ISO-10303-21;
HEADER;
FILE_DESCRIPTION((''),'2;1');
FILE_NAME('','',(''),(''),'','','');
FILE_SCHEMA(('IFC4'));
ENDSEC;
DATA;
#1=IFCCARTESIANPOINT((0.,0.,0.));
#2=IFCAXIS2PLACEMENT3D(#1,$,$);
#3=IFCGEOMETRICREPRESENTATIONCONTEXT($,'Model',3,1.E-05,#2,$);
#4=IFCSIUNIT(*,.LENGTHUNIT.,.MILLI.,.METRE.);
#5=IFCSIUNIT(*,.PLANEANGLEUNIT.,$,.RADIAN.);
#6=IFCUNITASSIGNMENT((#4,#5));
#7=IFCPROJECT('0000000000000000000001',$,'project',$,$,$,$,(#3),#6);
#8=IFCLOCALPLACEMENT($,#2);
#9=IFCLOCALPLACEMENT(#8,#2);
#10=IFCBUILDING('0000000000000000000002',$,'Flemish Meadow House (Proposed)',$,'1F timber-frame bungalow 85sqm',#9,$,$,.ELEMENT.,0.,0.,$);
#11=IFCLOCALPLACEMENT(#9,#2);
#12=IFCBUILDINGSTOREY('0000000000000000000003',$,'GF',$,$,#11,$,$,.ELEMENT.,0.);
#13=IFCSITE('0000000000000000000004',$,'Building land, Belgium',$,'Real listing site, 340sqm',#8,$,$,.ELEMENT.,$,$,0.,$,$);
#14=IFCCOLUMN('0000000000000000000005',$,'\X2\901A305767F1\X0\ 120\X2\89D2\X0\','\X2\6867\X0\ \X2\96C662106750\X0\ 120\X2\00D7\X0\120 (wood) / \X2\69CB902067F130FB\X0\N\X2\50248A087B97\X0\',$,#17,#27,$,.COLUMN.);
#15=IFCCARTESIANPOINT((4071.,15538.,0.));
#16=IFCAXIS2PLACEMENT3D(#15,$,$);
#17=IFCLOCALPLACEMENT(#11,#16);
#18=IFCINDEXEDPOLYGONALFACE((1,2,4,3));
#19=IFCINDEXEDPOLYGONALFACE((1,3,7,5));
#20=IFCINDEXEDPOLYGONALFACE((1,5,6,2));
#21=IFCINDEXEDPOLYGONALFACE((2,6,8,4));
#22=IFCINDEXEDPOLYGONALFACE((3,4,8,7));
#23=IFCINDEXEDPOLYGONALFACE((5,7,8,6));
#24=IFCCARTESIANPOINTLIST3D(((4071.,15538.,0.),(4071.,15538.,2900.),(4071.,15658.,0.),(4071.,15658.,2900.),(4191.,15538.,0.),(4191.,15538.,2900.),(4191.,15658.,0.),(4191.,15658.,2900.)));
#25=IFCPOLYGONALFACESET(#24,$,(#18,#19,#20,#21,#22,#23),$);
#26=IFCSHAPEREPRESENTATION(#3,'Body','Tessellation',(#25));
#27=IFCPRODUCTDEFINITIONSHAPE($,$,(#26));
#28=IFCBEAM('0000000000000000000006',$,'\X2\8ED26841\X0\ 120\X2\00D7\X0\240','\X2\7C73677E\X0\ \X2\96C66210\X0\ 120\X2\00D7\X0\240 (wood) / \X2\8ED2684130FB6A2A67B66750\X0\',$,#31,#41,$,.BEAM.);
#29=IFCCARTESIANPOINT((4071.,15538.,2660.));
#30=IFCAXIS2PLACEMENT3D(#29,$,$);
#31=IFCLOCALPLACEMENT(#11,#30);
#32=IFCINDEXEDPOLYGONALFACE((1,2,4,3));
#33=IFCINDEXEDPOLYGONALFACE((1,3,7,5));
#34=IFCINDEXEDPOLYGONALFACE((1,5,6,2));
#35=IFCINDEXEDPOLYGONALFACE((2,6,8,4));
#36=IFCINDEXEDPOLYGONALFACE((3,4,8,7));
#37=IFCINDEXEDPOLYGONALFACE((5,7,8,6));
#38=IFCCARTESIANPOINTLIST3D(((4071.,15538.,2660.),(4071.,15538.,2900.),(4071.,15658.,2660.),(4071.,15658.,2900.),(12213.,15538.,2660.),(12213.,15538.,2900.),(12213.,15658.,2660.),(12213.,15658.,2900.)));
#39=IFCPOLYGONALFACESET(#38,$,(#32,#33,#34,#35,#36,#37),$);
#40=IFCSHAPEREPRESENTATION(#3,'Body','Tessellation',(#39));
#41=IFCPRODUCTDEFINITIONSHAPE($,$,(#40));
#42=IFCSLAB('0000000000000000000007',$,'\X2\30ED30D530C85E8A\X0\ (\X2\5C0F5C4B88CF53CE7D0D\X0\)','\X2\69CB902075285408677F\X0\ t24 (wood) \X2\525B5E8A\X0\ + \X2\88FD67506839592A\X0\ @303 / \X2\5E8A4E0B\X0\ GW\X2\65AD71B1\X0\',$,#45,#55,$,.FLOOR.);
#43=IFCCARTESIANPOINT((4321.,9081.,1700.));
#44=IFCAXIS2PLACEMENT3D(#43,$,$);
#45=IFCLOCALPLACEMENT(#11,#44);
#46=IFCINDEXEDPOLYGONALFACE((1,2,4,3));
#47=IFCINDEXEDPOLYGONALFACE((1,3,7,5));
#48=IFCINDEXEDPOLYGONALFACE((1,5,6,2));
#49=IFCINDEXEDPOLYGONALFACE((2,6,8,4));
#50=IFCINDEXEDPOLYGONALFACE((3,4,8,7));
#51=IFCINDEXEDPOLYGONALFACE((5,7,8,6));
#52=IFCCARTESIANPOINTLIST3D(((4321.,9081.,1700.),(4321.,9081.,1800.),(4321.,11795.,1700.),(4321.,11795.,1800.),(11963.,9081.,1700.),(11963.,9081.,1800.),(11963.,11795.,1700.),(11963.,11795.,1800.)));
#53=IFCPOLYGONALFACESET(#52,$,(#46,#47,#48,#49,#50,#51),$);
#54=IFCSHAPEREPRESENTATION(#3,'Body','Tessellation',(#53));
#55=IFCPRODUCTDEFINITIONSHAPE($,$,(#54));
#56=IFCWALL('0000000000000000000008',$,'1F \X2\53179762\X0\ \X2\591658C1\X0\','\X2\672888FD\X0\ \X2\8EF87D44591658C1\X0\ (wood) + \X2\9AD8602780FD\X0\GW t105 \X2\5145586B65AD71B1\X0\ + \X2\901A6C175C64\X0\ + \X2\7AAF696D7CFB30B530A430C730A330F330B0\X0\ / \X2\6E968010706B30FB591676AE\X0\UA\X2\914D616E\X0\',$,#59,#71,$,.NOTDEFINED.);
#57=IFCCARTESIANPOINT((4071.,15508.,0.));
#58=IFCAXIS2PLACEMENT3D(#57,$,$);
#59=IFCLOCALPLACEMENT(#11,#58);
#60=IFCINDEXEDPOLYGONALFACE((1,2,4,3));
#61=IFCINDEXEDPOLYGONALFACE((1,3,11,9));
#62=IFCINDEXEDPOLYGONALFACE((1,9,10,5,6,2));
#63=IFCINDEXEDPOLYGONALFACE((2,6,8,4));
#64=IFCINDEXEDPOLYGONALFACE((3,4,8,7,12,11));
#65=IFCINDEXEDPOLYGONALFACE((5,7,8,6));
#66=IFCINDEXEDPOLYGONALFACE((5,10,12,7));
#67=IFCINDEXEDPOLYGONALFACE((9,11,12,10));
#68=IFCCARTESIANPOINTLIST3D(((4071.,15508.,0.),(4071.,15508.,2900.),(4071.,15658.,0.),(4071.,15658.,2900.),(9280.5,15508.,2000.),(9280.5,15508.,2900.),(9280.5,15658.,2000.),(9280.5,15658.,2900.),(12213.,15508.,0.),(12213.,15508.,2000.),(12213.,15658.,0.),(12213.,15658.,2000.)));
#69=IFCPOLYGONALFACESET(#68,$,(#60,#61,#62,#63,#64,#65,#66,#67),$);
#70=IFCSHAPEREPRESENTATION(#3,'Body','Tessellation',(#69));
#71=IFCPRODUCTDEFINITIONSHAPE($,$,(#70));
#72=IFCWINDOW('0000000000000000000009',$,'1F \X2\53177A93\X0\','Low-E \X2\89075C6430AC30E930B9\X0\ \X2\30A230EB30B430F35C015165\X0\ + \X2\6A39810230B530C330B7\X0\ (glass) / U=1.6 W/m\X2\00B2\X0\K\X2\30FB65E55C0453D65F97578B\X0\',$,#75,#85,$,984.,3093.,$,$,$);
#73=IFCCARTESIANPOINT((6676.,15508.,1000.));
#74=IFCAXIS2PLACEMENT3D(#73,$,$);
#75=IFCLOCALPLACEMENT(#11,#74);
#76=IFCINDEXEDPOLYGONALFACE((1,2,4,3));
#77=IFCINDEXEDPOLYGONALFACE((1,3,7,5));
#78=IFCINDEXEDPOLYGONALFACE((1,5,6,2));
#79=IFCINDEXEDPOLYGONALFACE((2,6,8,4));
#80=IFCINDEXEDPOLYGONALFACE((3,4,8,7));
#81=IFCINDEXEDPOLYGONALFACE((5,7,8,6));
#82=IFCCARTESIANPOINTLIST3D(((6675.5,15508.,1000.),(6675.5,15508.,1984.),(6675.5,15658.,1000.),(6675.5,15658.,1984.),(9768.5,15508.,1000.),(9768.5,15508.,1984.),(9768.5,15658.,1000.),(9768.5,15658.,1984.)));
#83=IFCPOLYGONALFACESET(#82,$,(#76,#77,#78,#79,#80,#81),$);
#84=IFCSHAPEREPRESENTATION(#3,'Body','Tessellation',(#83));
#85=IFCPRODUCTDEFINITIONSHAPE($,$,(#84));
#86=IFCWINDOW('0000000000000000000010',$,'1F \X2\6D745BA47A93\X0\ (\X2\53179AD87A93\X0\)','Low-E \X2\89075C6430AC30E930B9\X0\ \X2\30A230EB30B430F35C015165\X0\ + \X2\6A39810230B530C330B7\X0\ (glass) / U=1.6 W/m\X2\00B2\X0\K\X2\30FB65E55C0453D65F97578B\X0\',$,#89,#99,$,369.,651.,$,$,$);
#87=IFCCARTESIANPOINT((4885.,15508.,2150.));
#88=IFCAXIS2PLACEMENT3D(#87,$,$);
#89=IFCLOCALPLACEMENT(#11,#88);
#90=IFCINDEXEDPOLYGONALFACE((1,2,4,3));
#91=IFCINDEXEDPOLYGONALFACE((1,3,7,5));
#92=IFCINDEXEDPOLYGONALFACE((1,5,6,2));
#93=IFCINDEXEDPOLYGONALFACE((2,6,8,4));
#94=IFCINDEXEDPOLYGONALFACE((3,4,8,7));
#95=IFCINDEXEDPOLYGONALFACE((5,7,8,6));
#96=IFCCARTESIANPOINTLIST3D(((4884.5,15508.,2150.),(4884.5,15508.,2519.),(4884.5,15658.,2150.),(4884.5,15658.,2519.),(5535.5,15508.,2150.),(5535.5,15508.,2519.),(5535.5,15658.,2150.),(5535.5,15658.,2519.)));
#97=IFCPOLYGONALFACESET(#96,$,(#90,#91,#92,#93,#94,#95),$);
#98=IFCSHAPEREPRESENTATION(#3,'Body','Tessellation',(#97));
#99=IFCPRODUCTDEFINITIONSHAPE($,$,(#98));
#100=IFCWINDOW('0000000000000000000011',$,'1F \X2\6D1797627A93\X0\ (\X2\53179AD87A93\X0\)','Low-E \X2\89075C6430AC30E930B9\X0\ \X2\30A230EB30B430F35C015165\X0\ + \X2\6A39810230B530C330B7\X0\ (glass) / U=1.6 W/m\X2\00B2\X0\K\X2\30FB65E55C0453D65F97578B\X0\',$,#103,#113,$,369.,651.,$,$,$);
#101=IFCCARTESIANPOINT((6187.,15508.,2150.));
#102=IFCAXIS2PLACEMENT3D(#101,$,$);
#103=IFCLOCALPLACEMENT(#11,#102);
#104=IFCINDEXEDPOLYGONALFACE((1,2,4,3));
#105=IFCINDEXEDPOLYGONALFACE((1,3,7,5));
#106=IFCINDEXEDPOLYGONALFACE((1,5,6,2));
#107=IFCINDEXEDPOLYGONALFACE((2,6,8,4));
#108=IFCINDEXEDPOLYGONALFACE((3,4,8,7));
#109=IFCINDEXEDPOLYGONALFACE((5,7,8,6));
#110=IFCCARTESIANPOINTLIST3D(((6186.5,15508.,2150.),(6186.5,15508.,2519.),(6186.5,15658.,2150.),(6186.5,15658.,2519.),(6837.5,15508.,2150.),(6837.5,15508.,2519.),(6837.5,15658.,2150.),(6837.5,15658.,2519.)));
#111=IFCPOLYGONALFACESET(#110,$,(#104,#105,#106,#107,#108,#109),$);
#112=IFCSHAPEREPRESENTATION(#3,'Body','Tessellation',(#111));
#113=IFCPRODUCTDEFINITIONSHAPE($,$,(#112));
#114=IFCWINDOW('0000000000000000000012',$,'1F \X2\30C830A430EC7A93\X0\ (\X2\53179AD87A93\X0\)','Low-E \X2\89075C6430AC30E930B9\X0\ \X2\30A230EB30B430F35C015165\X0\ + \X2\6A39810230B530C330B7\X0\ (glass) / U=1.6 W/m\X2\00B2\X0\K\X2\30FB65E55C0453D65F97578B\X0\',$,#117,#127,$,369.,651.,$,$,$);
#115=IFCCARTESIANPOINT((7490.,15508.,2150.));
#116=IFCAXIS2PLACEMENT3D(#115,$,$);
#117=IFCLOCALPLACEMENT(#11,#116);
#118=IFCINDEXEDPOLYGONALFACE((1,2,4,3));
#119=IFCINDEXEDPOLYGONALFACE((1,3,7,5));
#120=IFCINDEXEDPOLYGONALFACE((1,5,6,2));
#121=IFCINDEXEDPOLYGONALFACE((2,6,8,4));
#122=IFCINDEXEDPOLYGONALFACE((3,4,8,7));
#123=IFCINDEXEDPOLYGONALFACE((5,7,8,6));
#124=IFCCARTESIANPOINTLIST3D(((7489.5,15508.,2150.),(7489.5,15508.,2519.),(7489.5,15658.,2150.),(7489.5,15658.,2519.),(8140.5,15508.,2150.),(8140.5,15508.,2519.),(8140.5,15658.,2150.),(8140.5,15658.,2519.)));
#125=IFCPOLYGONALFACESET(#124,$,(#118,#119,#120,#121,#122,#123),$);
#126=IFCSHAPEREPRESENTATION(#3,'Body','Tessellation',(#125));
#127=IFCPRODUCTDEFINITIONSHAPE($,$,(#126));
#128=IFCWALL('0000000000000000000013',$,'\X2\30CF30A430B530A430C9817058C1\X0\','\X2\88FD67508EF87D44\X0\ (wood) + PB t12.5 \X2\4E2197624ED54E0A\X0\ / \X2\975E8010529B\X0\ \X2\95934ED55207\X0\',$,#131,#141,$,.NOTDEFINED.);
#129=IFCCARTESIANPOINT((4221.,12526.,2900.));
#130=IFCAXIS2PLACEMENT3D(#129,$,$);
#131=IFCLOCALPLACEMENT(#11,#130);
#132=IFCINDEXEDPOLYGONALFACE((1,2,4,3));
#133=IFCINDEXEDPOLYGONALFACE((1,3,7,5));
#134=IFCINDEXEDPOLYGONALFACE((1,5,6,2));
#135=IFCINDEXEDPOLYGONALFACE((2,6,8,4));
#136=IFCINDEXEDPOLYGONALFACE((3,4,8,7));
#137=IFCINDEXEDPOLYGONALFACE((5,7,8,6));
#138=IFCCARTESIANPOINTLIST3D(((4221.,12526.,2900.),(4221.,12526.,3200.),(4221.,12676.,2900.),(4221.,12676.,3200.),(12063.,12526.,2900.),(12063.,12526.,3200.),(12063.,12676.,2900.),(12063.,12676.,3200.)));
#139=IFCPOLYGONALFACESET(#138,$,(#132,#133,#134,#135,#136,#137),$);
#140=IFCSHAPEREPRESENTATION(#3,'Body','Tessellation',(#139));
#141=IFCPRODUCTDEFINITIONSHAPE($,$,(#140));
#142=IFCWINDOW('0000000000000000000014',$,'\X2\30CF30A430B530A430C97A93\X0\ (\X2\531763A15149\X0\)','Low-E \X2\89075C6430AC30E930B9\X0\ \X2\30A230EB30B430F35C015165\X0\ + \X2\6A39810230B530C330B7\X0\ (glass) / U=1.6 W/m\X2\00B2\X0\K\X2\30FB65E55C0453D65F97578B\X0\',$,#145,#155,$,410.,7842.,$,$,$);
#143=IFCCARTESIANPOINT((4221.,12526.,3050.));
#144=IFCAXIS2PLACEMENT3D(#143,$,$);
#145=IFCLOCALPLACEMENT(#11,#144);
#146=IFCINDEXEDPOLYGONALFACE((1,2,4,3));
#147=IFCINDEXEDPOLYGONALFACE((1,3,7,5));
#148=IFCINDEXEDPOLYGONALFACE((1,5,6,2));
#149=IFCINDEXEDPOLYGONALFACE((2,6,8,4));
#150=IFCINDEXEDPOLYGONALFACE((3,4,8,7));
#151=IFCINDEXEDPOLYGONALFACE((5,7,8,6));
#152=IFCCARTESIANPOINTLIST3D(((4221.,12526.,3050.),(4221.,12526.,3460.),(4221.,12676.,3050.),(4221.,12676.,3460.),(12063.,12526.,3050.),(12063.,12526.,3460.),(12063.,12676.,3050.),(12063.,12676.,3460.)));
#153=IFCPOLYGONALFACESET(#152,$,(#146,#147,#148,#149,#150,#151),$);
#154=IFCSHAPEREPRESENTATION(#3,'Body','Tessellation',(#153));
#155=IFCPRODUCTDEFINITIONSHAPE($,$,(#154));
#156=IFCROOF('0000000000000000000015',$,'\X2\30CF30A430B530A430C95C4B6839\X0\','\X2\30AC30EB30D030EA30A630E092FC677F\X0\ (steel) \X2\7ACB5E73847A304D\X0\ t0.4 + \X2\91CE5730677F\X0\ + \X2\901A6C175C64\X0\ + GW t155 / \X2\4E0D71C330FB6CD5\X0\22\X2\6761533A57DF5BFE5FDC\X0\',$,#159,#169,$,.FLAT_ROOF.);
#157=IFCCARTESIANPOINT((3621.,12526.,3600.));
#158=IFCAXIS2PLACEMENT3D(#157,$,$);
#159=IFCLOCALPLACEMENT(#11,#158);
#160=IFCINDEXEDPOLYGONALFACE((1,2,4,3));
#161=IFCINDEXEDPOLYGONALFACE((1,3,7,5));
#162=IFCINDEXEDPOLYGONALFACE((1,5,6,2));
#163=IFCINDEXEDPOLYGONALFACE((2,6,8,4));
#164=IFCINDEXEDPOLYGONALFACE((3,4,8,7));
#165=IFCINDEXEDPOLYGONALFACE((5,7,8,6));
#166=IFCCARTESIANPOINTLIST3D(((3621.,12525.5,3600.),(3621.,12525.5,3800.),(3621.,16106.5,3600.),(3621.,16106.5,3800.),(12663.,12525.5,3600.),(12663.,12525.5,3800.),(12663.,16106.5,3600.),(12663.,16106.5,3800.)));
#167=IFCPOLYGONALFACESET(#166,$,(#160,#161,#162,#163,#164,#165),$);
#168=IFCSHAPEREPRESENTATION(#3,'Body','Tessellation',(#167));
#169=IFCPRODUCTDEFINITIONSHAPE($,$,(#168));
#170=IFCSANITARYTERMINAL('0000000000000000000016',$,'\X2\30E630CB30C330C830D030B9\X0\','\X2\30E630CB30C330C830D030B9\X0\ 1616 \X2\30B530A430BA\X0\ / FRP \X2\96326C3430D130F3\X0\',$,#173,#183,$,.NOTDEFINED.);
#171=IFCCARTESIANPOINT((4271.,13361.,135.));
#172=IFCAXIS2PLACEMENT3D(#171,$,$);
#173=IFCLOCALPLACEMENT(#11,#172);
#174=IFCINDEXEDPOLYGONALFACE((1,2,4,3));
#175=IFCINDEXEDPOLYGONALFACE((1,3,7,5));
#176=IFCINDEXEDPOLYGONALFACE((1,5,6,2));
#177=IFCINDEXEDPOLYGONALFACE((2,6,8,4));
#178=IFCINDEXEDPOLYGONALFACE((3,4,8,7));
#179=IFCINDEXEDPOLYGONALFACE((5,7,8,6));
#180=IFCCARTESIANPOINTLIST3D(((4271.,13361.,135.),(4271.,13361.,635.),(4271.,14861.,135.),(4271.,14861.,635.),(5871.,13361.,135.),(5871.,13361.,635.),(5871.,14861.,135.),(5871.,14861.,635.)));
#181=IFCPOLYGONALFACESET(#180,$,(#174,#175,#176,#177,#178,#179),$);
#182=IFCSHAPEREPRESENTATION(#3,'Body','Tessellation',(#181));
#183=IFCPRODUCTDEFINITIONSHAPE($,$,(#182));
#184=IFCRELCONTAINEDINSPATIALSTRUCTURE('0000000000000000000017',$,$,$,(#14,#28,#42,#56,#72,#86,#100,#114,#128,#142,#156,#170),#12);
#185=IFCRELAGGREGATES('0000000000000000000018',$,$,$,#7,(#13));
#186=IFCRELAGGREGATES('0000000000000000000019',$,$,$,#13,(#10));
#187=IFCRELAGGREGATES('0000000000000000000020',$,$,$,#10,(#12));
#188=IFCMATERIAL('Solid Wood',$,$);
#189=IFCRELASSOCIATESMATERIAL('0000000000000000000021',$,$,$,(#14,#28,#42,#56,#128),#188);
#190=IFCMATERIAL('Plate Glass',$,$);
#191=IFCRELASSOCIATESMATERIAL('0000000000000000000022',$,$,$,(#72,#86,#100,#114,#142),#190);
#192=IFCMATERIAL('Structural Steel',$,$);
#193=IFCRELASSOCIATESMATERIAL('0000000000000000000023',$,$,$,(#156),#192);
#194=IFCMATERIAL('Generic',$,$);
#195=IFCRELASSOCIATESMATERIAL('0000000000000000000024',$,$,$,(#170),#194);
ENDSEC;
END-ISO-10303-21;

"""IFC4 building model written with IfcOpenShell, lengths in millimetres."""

from ifc_helpers import new_model, si_unit, frame, frame_2d, origin, place, context, project, spatial, rectangle, extrude, material, element, fill, save


model = new_model("IFC4")

# Units and contexts
model_context = context("Model", 3, precision=1e-05, world=origin())
ifc_project = project(units=[si_unit("LENGTHUNIT", "METRE", prefix="MILLI"), si_unit("PLANEANGLEUNIT", "RADIAN")], contexts=[model_context])

# Site, building, storey
site_placement = place(None, origin())
site = spatial("IfcSite", under=ifc_project, at=site_placement, Name="Building land, Belgium", ObjectType="Real listing site, 340sqm", CompositionType="ELEMENT", RefElevation=0.0)
building_placement = place(site_placement, origin())
building = spatial("IfcBuilding", under=site, at=building_placement, Name="Flemish Meadow House (Proposed)", ObjectType="1F timber-frame bungalow 85sqm", CompositionType="ELEMENT", ElevationOfRefHeight=0.0, ElevationOfTerrain=0.0)
storey_placement = place(building_placement, origin())
storey = spatial("IfcBuildingStorey", under=building, at=storey_placement, Name="GF", CompositionType="ELEMENT", Elevation=0.0)

# Column
ifc_material_1 = material(Name="Solid Wood")
column_1_placement = place(storey_placement, frame((4071.0, 15538.0, 0.0)))
element("IfcColumn", 1, at=column_1_placement, inside=storey, material=ifc_material_1, Name="通し柱 120角", Description="桧 集成材 120×120 (wood) / 構造柱・N値計算", PredefinedType="COLUMN", context=model_context, shape_type="SweptSolid", body=[
    extrude(rectangle(XDim=120.0, YDim=120.0, at=frame_2d((60.0, 60.0))), frame((4071.0, 15538.0, 0.0)), (0.0, 0.0, 1.0), 2900.0),
])

# Beam
beam_1_placement = place(storey_placement, frame((4071.0, 15538.0, 2660.0)))
element("IfcBeam", 2, at=beam_1_placement, inside=storey, material=ifc_material_1, Name="軒桁 120×240", Description="米松 集成 120×240 (wood) / 軒桁・横架材", PredefinedType="BEAM", context=model_context, shape_type="SweptSolid", body=[
    extrude(rectangle(XDim=8142.0, YDim=120.0, at=frame_2d((4071.0, 60.0))), frame((4071.0, 15538.0, 2660.0)), (0.0, 0.0, 1.0), 240.0),
])

# Slab
slab_placement = place(storey_placement, frame((4321.0, 9081.0, 1700.0)))
element("IfcSlab", 3, at=slab_placement, inside=storey, material=ifc_material_1, Name="ロフト床 (小屋裏収納)", Description="構造用合板 t24 (wood) 剛床 + 製材根太 @303 / 床下 GW断熱", PredefinedType="FLOOR", context=model_context, shape_type="SweptSolid", body=[
    extrude(rectangle(XDim=7642.0, YDim=2714.0, at=frame_2d((3821.0, 1357.0))), frame((4321.0, 9081.0, 1700.0)), (0.0, 0.0, 1.0), 100.0),
])

# Wall, openings, windows
wall_1_placement = place(storey_placement, frame((4071.0, 15508.0, 0.0)))
wall_1 = element("IfcWall", 4, at=wall_1_placement, inside=storey, material=ifc_material_1, Name="1F 北面 外壁", Description="木製 軸組外壁 (wood) + 高性能GW t105 充填断熱 + 通気層 + 窯業系サイディング / 準耐火・外皮UA配慮", PredefinedType="NOTDEFINED", context=model_context, shape_type="SweptSolid", body=[
    extrude(rectangle(XDim=8142.0, YDim=150.0, at=frame_2d((4071.0, 75.0))), frame((4071.0, 15508.0, 0.0)), (0.0, 0.0, 1.0), 2900.0),
])
opening_1_placement = place(storey_placement, frame((6676.0, 15508.0, 1000.0)))
opening_1 = element("IfcOpeningElement", 5, at=opening_1_placement, cuts=wall_1, PredefinedType="NOTDEFINED", context=model_context, shape_type="SweptSolid", body=[
    extrude(rectangle(XDim=3093.0, YDim=150.0, at=frame_2d((1546.0, 75.0))), frame((6676.0, 15508.0, 1000.0)), (0.0, 0.0, 1.0), 984.0),
])
opening_2_placement = place(storey_placement, frame((4885.0, 15508.0, 2150.0)))
opening_2 = element("IfcOpeningElement", 6, at=opening_2_placement, cuts=wall_1, PredefinedType="NOTDEFINED", context=model_context, shape_type="SweptSolid", body=[
    extrude(rectangle(XDim=651.0, YDim=150.0, at=frame_2d((325.0, 75.0))), frame((4885.0, 15508.0, 2150.0)), (0.0, 0.0, 1.0), 369.0),
])
opening_3_placement = place(storey_placement, frame((6187.0, 15508.0, 2150.0)))
opening_3 = element("IfcOpeningElement", 7, at=opening_3_placement, cuts=wall_1, PredefinedType="NOTDEFINED", context=model_context, shape_type="SweptSolid", body=[
    extrude(rectangle(XDim=651.0, YDim=150.0, at=frame_2d((325.0, 75.0))), frame((6187.0, 15508.0, 2150.0)), (0.0, 0.0, 1.0), 369.0),
])
opening_4_placement = place(storey_placement, frame((7490.0, 15508.0, 2150.0)))
opening_4 = element("IfcOpeningElement", 8, at=opening_4_placement, cuts=wall_1, PredefinedType="NOTDEFINED", context=model_context, shape_type="SweptSolid", body=[
    extrude(rectangle(XDim=651.0, YDim=150.0, at=frame_2d((325.0, 75.0))), frame((7490.0, 15508.0, 2150.0)), (0.0, 0.0, 1.0), 369.0),
])
ifc_material_2 = material(Name="Plate Glass")
window_1_placement = place(storey_placement, frame((6676.0, 15508.0, 1000.0)))
window_1 = element("IfcWindow", 9, at=window_1_placement, inside=storey, material=ifc_material_2, Name="1F 北窓", Description="Low-E 複層ガラス アルゴン封入 + 樹脂サッシ (glass) / U=1.6 W/m²K・日射取得型", OverallHeight=984.0, OverallWidth=3093.0, context=model_context, shape_type="SweptSolid", body=[
    extrude(rectangle(XDim=3093.0, YDim=150.0, at=frame_2d((1546.0, 75.0))), frame((6676.0, 15508.0, 1000.0)), (0.0, 0.0, 1.0), 984.0),
])
fill(opening_1, window_1)
window_2_placement = place(storey_placement, frame((4885.0, 15508.0, 2150.0)))
window_2 = element("IfcWindow", 10, at=window_2_placement, inside=storey, material=ifc_material_2, Name="1F 浴室窓 (北高窓)", Description="Low-E 複層ガラス アルゴン封入 + 樹脂サッシ (glass) / U=1.6 W/m²K・日射取得型", OverallHeight=369.0, OverallWidth=651.0, context=model_context, shape_type="SweptSolid", body=[
    extrude(rectangle(XDim=651.0, YDim=150.0, at=frame_2d((325.0, 75.0))), frame((4885.0, 15508.0, 2150.0)), (0.0, 0.0, 1.0), 369.0),
])
fill(opening_2, window_2)
window_3_placement = place(storey_placement, frame((6187.0, 15508.0, 2150.0)))
window_3 = element("IfcWindow", 11, at=window_3_placement, inside=storey, material=ifc_material_2, Name="1F 洗面窓 (北高窓)", Description="Low-E 複層ガラス アルゴン封入 + 樹脂サッシ (glass) / U=1.6 W/m²K・日射取得型", OverallHeight=369.0, OverallWidth=651.0, context=model_context, shape_type="SweptSolid", body=[
    extrude(rectangle(XDim=651.0, YDim=150.0, at=frame_2d((325.0, 75.0))), frame((6187.0, 15508.0, 2150.0)), (0.0, 0.0, 1.0), 369.0),
])
fill(opening_3, window_3)
window_4_placement = place(storey_placement, frame((7490.0, 15508.0, 2150.0)))
window_4 = element("IfcWindow", 12, at=window_4_placement, inside=storey, material=ifc_material_2, Name="1F トイレ窓 (北高窓)", Description="Low-E 複層ガラス アルゴン封入 + 樹脂サッシ (glass) / U=1.6 W/m²K・日射取得型", OverallHeight=369.0, OverallWidth=651.0, context=model_context, shape_type="SweptSolid", body=[
    extrude(rectangle(XDim=651.0, YDim=150.0, at=frame_2d((325.0, 75.0))), frame((7490.0, 15508.0, 2150.0)), (0.0, 0.0, 1.0), 369.0),
])
fill(opening_4, window_4)

# Wall, opening, window
wall_2_placement = place(storey_placement, frame((4221.0, 12526.0, 2900.0)))
wall_2 = element("IfcWall", 13, at=wall_2_placement, inside=storey, material=ifc_material_1, Name="ハイサイド腰壁", Description="製材軸組 (wood) + PB t12.5 両面仕上 / 非耐力 間仕切", PredefinedType="NOTDEFINED", context=model_context, shape_type="SweptSolid", body=[
    extrude(rectangle(XDim=7842.0, YDim=150.0, at=frame_2d((3921.0, 75.0))), frame((4221.0, 12526.0, 2900.0)), (0.0, 0.0, 1.0), 700.0),
])
opening_5_placement = place(storey_placement, frame((4221.0, 12526.0, 3050.0)))
opening_5 = element("IfcOpeningElement", 14, at=opening_5_placement, cuts=wall_2, PredefinedType="NOTDEFINED", context=model_context, shape_type="SweptSolid", body=[
    extrude(rectangle(XDim=7842.0, YDim=150.0, at=frame_2d((3921.0, 75.0))), frame((4221.0, 12526.0, 3050.0)), (0.0, 0.0, 1.0), 410.0),
])
window_5_placement = place(storey_placement, frame((4221.0, 12526.0, 3050.0)))
window_5 = element("IfcWindow", 15, at=window_5_placement, inside=storey, material=ifc_material_2, Name="ハイサイド窓 (北採光)", Description="Low-E 複層ガラス アルゴン封入 + 樹脂サッシ (glass) / U=1.6 W/m²K・日射取得型", OverallHeight=410.0, OverallWidth=7842.0, context=model_context, shape_type="SweptSolid", body=[
    extrude(rectangle(XDim=7842.0, YDim=150.0, at=frame_2d((3921.0, 75.0))), frame((4221.0, 12526.0, 3050.0)), (0.0, 0.0, 1.0), 410.0),
])
fill(opening_5, window_5)

# Roof
ifc_material_3 = material(Name="Structural Steel")
roof_placement = place(storey_placement, frame((3621.0, 12526.0, 3600.0)))
element("IfcRoof", 16, at=roof_placement, inside=storey, material=ifc_material_3, Name="ハイサイド屋根", Description="ガルバリウム鋼板 (steel) 立平葺き t0.4 + 野地板 + 通気層 + GW t155 / 不燃・法22条区域対応", PredefinedType="FLAT_ROOF", context=model_context, shape_type="SweptSolid", body=[
    extrude(rectangle(XDim=9042.0, YDim=3581.0, at=frame_2d((4521.0, 1790.0))), frame((3621.0, 12526.0, 3600.0)), (0.0, 0.0, 1.0), 200.0),
])

# Sanitary terminal
ifc_material_4 = material(Name="Generic")
sanitary_terminal_placement = place(storey_placement, frame((4271.0, 13361.0, 135.0)))
element("IfcSanitaryTerminal", 17, at=sanitary_terminal_placement, inside=storey, material=ifc_material_4, Name="ユニットバス", Description="ユニットバス 1616 サイズ / FRP 防水パン", PredefinedType="NOTDEFINED", context=model_context, shape_type="SweptSolid", body=[
    extrude(rectangle(XDim=1600.0, YDim=1500.0, at=frame_2d((800.0, 750.0))), frame((4271.0, 13361.0, 135.0)), (0.0, 0.0, 1.0), 500.0),
])

save(model, "model.ifc")
